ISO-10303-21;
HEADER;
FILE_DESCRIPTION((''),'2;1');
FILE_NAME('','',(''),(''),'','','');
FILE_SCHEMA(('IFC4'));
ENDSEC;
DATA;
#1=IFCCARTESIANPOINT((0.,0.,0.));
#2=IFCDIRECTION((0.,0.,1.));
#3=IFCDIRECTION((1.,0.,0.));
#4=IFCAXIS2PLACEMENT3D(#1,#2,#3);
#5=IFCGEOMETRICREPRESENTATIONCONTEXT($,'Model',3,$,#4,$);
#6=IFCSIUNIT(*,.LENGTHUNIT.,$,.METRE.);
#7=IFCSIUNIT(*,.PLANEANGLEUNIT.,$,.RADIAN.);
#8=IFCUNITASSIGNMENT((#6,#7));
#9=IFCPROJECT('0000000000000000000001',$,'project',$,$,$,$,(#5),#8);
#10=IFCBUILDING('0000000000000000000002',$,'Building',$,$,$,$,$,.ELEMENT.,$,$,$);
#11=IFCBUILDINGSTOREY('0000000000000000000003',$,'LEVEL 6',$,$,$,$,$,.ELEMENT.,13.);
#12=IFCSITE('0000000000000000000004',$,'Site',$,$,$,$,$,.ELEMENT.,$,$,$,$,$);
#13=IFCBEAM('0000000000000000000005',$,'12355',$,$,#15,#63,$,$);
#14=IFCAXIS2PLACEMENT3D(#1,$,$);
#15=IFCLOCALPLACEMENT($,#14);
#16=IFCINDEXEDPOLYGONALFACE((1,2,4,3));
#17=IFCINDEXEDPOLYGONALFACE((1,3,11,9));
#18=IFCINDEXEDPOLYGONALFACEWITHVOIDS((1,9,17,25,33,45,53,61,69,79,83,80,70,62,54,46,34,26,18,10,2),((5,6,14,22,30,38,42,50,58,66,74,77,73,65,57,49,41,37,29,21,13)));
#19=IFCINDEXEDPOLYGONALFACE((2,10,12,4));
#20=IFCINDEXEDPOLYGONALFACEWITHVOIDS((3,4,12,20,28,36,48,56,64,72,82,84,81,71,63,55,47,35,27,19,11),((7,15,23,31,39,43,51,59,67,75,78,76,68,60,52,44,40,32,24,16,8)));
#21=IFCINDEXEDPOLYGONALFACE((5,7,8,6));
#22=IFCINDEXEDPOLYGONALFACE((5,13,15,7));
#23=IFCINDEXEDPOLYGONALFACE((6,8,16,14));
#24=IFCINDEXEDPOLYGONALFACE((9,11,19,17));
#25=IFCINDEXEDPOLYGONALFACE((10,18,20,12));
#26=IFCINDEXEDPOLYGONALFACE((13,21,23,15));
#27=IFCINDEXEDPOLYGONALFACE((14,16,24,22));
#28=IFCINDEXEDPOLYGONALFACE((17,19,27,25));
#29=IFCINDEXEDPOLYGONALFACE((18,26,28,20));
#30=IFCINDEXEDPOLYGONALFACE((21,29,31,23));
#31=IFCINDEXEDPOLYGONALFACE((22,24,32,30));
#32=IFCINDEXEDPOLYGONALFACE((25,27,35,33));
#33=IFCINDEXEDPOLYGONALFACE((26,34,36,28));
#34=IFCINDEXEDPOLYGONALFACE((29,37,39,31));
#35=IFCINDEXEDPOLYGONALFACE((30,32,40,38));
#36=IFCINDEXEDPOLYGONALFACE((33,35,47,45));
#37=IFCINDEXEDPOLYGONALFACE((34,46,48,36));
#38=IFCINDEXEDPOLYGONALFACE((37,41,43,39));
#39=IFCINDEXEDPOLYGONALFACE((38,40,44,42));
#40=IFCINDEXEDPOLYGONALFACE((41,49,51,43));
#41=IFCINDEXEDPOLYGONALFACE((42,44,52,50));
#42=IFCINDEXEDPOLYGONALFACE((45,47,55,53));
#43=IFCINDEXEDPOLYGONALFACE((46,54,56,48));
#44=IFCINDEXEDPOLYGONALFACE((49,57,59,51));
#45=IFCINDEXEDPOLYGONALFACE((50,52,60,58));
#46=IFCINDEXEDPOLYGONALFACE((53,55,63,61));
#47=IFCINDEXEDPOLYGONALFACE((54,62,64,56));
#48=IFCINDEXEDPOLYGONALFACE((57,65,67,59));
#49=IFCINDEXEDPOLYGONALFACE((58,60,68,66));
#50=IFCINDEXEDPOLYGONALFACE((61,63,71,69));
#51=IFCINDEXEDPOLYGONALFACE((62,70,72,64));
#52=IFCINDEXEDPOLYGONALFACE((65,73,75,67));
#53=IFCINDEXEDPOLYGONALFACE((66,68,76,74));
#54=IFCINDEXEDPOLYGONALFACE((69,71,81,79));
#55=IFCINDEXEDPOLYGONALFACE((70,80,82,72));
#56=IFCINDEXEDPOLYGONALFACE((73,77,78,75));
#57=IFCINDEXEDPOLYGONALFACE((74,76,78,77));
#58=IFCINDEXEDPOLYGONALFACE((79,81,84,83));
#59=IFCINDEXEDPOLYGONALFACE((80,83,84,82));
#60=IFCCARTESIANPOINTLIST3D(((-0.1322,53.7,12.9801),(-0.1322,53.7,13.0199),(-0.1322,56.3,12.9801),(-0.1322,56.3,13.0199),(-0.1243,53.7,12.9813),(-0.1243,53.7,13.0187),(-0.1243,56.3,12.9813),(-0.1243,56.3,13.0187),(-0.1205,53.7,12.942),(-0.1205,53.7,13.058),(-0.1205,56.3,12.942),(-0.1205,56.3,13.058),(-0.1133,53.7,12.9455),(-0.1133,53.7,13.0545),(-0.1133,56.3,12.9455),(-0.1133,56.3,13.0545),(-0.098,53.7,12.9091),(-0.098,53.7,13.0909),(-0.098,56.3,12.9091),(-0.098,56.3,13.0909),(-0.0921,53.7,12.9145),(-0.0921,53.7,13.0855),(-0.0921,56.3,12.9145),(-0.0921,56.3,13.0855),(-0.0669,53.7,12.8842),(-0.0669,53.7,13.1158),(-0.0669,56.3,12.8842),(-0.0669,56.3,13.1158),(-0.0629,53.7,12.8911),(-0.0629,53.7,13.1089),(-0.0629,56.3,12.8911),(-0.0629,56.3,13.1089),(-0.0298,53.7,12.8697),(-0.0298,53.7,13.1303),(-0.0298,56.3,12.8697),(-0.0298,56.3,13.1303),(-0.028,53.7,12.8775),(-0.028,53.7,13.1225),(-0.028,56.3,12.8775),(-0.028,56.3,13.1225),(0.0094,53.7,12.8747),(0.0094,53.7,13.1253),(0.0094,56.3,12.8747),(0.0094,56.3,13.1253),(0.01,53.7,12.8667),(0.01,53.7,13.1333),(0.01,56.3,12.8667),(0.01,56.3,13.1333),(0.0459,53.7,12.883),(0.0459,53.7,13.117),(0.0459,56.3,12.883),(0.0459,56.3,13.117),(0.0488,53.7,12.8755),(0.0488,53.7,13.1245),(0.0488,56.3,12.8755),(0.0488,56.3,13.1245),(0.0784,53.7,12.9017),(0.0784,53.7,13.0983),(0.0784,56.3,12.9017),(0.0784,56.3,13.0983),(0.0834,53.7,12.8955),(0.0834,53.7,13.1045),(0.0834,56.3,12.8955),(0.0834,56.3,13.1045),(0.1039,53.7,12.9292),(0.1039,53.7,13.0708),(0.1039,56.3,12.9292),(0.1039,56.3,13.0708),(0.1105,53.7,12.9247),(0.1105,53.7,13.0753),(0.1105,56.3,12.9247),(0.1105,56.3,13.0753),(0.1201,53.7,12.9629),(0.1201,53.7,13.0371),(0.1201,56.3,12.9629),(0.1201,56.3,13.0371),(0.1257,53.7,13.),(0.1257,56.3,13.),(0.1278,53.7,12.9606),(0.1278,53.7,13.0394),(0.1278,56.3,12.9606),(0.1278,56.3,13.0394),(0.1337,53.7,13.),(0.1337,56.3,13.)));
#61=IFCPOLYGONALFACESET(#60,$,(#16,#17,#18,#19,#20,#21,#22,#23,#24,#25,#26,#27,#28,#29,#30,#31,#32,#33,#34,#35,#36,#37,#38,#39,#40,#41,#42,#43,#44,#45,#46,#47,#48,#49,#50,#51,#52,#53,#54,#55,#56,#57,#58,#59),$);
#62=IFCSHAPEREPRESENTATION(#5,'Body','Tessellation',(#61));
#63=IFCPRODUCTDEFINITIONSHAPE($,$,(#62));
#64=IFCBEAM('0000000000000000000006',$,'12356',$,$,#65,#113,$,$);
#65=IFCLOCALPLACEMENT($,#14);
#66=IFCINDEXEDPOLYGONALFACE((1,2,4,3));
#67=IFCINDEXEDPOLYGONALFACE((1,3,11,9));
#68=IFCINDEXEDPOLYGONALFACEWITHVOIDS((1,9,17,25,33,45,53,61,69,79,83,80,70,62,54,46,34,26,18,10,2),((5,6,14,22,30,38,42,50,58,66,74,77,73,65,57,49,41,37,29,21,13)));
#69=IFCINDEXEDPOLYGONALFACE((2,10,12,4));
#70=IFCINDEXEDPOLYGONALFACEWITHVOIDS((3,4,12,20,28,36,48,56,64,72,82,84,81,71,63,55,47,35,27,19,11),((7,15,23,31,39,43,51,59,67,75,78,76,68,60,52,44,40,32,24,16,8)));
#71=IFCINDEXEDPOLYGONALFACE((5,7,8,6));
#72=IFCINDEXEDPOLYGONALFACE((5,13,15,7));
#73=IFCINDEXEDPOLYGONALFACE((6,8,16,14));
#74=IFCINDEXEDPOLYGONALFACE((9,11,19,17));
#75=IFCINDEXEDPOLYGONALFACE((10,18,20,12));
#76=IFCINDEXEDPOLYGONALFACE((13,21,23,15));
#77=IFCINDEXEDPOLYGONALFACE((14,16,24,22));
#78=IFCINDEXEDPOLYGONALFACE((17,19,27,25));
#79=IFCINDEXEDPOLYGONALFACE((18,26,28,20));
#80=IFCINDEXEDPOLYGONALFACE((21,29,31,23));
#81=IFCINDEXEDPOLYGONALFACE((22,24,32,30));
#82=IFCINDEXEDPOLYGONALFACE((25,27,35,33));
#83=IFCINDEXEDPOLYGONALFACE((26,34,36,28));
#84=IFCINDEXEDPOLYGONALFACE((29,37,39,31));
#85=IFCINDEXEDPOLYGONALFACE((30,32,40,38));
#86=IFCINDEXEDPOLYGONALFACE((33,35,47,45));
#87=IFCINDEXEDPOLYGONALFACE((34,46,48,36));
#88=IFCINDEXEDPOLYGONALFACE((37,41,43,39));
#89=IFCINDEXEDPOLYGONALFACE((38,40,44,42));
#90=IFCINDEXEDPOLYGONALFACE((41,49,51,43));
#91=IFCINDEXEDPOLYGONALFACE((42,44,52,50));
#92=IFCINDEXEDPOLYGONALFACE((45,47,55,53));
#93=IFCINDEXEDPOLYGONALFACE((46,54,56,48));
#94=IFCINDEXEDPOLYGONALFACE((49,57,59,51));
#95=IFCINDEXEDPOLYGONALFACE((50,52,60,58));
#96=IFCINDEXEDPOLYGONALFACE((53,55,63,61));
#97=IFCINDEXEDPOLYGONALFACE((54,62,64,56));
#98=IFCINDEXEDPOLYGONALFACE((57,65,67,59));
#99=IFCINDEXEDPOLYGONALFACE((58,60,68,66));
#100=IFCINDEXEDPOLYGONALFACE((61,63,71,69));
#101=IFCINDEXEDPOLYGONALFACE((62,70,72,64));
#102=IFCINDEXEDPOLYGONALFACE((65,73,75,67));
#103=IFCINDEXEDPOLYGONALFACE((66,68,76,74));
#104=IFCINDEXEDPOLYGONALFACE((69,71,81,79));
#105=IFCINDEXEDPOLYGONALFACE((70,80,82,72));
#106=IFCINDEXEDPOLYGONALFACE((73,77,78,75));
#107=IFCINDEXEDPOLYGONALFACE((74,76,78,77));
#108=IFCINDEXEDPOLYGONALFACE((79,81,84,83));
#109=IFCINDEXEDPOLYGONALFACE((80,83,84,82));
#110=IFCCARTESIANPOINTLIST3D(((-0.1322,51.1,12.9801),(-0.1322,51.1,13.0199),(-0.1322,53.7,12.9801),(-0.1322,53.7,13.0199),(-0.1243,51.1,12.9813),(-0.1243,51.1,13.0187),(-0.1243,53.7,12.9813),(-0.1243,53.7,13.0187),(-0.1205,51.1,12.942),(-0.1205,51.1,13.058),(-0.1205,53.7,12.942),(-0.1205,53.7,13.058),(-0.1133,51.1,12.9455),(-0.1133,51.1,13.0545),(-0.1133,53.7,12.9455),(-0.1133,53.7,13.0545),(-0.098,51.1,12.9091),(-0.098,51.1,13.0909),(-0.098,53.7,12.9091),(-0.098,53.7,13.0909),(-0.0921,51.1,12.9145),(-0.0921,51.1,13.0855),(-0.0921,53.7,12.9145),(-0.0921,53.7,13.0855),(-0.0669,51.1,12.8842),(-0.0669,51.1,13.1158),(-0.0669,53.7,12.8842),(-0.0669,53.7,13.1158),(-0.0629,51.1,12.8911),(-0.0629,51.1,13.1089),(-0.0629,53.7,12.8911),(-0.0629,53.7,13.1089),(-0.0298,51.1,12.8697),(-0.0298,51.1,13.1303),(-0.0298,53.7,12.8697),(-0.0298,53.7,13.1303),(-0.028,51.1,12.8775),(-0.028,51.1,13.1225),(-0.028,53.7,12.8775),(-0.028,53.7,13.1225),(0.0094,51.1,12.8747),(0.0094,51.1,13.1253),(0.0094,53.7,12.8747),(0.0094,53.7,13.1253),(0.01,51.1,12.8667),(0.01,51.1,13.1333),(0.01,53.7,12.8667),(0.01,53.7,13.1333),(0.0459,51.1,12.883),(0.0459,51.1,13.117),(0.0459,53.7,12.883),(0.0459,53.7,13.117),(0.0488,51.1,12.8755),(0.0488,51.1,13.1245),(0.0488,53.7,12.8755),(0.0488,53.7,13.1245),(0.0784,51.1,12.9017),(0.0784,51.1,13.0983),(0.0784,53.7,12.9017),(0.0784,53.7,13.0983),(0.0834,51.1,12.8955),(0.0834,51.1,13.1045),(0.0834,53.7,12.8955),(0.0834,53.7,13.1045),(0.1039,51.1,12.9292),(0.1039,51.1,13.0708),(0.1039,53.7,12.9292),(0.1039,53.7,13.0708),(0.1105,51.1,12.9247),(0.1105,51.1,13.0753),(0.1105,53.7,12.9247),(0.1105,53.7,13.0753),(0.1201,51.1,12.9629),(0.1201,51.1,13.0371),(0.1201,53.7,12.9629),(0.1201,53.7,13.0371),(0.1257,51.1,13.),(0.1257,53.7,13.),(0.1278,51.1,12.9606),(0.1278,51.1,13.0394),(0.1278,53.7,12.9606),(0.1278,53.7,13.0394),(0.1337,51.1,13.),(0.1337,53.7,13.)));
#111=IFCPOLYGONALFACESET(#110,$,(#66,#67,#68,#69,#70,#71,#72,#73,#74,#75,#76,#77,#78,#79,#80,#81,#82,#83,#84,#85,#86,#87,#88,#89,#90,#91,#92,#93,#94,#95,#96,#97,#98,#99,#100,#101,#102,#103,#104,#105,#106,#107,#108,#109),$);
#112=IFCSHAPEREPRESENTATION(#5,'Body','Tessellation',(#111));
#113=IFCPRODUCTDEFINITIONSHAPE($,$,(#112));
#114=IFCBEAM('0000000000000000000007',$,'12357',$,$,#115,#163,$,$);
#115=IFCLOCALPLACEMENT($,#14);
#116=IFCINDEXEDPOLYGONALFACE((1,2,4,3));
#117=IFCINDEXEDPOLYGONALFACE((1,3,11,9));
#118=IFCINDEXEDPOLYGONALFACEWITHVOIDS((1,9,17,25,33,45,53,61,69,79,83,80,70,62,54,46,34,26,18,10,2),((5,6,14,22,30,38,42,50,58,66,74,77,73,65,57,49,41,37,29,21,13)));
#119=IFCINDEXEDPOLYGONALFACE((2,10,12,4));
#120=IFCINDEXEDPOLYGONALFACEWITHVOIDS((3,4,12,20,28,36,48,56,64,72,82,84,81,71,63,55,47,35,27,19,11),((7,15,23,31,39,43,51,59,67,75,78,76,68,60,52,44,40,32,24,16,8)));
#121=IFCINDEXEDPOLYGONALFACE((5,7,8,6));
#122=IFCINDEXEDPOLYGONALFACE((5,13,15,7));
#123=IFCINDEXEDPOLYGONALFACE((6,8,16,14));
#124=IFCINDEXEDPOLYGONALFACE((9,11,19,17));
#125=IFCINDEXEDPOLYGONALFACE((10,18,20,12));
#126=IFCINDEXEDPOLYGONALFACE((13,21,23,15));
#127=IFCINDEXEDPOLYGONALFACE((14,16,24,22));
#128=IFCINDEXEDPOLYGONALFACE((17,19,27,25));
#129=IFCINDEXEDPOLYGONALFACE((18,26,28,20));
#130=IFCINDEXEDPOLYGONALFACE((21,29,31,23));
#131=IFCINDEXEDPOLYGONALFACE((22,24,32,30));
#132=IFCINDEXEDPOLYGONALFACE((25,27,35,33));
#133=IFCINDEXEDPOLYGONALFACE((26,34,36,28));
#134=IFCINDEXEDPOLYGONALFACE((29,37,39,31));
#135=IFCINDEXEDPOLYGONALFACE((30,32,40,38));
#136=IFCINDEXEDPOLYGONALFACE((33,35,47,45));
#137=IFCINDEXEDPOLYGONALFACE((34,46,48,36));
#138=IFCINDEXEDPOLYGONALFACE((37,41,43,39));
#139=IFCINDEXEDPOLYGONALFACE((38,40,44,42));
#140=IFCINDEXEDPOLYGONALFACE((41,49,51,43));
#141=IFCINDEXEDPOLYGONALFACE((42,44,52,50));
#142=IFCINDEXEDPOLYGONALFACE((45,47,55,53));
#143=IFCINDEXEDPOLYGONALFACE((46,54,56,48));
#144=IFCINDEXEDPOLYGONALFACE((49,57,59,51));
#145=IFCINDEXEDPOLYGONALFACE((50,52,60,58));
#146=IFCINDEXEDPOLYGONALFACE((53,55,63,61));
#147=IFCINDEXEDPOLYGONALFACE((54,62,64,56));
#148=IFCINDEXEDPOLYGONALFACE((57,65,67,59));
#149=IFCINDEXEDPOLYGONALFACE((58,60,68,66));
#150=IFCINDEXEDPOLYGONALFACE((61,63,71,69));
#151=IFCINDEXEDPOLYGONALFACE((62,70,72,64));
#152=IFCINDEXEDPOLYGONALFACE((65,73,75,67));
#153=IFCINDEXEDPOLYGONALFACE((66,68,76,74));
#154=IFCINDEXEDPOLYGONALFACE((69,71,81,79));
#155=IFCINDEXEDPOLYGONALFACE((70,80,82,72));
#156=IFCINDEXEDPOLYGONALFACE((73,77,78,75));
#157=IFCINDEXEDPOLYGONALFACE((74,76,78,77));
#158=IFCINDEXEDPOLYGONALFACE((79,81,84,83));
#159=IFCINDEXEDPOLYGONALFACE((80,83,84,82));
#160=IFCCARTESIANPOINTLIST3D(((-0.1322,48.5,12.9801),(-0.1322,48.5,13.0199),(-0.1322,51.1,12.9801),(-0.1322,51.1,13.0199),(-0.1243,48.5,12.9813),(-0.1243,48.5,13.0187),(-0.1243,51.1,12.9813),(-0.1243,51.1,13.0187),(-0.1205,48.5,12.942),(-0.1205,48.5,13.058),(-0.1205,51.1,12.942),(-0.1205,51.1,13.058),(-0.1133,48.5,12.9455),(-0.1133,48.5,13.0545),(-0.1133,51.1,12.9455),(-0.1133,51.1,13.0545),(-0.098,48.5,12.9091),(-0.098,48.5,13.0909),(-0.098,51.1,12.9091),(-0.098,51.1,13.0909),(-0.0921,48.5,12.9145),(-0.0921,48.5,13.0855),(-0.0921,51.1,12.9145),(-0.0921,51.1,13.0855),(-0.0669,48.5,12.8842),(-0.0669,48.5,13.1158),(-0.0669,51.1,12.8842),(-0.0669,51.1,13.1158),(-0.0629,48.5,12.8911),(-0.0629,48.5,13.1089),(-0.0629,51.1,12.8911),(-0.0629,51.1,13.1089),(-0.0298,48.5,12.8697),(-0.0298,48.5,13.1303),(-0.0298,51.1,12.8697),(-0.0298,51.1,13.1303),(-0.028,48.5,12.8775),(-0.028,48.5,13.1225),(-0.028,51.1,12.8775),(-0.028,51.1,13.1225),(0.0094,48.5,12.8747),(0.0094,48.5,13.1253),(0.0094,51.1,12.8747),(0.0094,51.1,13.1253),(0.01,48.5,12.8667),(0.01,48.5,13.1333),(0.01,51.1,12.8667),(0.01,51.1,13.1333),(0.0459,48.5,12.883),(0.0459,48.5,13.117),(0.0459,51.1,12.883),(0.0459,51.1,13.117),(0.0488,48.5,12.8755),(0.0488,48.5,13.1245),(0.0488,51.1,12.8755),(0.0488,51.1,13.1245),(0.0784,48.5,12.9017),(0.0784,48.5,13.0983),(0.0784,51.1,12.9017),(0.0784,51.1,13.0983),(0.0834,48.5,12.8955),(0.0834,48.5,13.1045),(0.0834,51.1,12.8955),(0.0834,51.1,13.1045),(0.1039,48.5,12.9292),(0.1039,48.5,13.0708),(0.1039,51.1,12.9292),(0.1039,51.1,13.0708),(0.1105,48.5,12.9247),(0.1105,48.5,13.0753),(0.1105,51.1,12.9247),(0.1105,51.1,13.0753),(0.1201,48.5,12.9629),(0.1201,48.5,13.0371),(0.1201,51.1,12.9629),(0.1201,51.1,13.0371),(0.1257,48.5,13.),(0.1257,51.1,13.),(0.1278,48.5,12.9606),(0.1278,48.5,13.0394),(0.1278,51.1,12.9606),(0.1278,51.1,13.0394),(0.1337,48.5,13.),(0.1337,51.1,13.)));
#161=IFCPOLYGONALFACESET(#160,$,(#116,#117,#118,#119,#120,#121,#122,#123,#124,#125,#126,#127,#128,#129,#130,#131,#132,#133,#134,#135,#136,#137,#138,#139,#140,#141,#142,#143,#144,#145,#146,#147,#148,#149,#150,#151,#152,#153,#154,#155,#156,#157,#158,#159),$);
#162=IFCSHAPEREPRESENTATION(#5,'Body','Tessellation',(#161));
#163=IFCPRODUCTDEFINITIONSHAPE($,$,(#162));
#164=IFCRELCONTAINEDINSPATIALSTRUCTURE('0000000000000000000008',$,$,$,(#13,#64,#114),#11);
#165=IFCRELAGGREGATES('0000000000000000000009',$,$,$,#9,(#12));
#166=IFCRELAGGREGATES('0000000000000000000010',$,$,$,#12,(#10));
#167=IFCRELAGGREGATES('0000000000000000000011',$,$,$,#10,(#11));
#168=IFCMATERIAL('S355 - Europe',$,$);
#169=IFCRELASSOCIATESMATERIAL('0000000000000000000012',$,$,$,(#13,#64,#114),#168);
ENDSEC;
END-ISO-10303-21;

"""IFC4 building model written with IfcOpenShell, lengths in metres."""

from ifc_helpers import new_model, si_unit, frame, origin_with_axes, origin_2d_with_axis, place, context, project, spatial, hollow_circle, extrude, material, material_profile, profile_set, profile_usage, element, save


model = new_model("IFC4")

# Units and contexts
model_context = context("Model", 3, world=origin_with_axes())
ifc_project = project(units=[si_unit("LENGTHUNIT", "METRE"), si_unit("PLANEANGLEUNIT", "RADIAN")], contexts=[model_context])

# Site, building, storey
site = spatial("IfcSite", under=ifc_project, Name="Site", CompositionType="ELEMENT")
building = spatial("IfcBuilding", under=site, Name="Building", CompositionType="ELEMENT")
storey = spatial("IfcBuildingStorey", under=building, Name="LEVEL 6", CompositionType="ELEMENT", Elevation=13.0)

# Shared definitions
ifc_material = material(Name="S355 - Europe")

# Beams
ifc_material_profile_1 = material_profile(ifc_material, hollow_circle(Radius=0.1337, WallThickness=0.008, at=origin_2d_with_axis()))
ifc_profile_set_1 = profile_set([ifc_material_profile_1])
ifc_profile_usage_1 = profile_usage(ifc_profile_set_1, cardinal=10)
beam_1_placement = place(None, frame((0.0, 56.3, 13.0), z_axis=(0.0, -1.0, 0.0), x_axis=(1.0, 0.0, 0.0)))
element("IfcBeam", 1, at=beam_1_placement, inside=storey, material=ifc_profile_usage_1, Name="12355", context=model_context, shape_type="SweptSolid", body=[
    extrude(hollow_circle(Radius=0.1337, WallThickness=0.008, at=origin_2d_with_axis()), origin_with_axes(), (0.0, 0.0, 1.0), 2.6),
])
ifc_material_profile_2 = material_profile(ifc_material, hollow_circle(Radius=0.1337, WallThickness=0.008, at=origin_2d_with_axis()))
ifc_profile_set_2 = profile_set([ifc_material_profile_2])
ifc_profile_usage_2 = profile_usage(ifc_profile_set_2, cardinal=10)
beam_2_placement = place(None, frame((0.0, 53.7, 13.0), z_axis=(0.0, -1.0, 0.0), x_axis=(1.0, 0.0, 0.0)))
element("IfcBeam", 2, at=beam_2_placement, inside=storey, material=ifc_profile_usage_2, Name="12356", context=model_context, shape_type="SweptSolid", body=[
    extrude(hollow_circle(Radius=0.1337, WallThickness=0.008, at=origin_2d_with_axis()), origin_with_axes(), (0.0, 0.0, 1.0), 2.6),
])
ifc_material_profile_3 = material_profile(ifc_material, hollow_circle(Radius=0.1337, WallThickness=0.008, at=origin_2d_with_axis()))
ifc_profile_set_3 = profile_set([ifc_material_profile_3])
ifc_profile_usage_3 = profile_usage(ifc_profile_set_3, cardinal=10)
beam_3_placement = place(None, frame((0.0, 51.1, 13.0), z_axis=(0.0, -1.0, 0.0), x_axis=(1.0, 0.0, 0.0)))
element("IfcBeam", 3, at=beam_3_placement, inside=storey, material=ifc_profile_usage_3, Name="12357", context=model_context, shape_type="SweptSolid", body=[
    extrude(hollow_circle(Radius=0.1337, WallThickness=0.008, at=origin_2d_with_axis()), origin_with_axes(), (0.0, 0.0, 1.0), 2.6),
])

save(model, "model.ifc")
